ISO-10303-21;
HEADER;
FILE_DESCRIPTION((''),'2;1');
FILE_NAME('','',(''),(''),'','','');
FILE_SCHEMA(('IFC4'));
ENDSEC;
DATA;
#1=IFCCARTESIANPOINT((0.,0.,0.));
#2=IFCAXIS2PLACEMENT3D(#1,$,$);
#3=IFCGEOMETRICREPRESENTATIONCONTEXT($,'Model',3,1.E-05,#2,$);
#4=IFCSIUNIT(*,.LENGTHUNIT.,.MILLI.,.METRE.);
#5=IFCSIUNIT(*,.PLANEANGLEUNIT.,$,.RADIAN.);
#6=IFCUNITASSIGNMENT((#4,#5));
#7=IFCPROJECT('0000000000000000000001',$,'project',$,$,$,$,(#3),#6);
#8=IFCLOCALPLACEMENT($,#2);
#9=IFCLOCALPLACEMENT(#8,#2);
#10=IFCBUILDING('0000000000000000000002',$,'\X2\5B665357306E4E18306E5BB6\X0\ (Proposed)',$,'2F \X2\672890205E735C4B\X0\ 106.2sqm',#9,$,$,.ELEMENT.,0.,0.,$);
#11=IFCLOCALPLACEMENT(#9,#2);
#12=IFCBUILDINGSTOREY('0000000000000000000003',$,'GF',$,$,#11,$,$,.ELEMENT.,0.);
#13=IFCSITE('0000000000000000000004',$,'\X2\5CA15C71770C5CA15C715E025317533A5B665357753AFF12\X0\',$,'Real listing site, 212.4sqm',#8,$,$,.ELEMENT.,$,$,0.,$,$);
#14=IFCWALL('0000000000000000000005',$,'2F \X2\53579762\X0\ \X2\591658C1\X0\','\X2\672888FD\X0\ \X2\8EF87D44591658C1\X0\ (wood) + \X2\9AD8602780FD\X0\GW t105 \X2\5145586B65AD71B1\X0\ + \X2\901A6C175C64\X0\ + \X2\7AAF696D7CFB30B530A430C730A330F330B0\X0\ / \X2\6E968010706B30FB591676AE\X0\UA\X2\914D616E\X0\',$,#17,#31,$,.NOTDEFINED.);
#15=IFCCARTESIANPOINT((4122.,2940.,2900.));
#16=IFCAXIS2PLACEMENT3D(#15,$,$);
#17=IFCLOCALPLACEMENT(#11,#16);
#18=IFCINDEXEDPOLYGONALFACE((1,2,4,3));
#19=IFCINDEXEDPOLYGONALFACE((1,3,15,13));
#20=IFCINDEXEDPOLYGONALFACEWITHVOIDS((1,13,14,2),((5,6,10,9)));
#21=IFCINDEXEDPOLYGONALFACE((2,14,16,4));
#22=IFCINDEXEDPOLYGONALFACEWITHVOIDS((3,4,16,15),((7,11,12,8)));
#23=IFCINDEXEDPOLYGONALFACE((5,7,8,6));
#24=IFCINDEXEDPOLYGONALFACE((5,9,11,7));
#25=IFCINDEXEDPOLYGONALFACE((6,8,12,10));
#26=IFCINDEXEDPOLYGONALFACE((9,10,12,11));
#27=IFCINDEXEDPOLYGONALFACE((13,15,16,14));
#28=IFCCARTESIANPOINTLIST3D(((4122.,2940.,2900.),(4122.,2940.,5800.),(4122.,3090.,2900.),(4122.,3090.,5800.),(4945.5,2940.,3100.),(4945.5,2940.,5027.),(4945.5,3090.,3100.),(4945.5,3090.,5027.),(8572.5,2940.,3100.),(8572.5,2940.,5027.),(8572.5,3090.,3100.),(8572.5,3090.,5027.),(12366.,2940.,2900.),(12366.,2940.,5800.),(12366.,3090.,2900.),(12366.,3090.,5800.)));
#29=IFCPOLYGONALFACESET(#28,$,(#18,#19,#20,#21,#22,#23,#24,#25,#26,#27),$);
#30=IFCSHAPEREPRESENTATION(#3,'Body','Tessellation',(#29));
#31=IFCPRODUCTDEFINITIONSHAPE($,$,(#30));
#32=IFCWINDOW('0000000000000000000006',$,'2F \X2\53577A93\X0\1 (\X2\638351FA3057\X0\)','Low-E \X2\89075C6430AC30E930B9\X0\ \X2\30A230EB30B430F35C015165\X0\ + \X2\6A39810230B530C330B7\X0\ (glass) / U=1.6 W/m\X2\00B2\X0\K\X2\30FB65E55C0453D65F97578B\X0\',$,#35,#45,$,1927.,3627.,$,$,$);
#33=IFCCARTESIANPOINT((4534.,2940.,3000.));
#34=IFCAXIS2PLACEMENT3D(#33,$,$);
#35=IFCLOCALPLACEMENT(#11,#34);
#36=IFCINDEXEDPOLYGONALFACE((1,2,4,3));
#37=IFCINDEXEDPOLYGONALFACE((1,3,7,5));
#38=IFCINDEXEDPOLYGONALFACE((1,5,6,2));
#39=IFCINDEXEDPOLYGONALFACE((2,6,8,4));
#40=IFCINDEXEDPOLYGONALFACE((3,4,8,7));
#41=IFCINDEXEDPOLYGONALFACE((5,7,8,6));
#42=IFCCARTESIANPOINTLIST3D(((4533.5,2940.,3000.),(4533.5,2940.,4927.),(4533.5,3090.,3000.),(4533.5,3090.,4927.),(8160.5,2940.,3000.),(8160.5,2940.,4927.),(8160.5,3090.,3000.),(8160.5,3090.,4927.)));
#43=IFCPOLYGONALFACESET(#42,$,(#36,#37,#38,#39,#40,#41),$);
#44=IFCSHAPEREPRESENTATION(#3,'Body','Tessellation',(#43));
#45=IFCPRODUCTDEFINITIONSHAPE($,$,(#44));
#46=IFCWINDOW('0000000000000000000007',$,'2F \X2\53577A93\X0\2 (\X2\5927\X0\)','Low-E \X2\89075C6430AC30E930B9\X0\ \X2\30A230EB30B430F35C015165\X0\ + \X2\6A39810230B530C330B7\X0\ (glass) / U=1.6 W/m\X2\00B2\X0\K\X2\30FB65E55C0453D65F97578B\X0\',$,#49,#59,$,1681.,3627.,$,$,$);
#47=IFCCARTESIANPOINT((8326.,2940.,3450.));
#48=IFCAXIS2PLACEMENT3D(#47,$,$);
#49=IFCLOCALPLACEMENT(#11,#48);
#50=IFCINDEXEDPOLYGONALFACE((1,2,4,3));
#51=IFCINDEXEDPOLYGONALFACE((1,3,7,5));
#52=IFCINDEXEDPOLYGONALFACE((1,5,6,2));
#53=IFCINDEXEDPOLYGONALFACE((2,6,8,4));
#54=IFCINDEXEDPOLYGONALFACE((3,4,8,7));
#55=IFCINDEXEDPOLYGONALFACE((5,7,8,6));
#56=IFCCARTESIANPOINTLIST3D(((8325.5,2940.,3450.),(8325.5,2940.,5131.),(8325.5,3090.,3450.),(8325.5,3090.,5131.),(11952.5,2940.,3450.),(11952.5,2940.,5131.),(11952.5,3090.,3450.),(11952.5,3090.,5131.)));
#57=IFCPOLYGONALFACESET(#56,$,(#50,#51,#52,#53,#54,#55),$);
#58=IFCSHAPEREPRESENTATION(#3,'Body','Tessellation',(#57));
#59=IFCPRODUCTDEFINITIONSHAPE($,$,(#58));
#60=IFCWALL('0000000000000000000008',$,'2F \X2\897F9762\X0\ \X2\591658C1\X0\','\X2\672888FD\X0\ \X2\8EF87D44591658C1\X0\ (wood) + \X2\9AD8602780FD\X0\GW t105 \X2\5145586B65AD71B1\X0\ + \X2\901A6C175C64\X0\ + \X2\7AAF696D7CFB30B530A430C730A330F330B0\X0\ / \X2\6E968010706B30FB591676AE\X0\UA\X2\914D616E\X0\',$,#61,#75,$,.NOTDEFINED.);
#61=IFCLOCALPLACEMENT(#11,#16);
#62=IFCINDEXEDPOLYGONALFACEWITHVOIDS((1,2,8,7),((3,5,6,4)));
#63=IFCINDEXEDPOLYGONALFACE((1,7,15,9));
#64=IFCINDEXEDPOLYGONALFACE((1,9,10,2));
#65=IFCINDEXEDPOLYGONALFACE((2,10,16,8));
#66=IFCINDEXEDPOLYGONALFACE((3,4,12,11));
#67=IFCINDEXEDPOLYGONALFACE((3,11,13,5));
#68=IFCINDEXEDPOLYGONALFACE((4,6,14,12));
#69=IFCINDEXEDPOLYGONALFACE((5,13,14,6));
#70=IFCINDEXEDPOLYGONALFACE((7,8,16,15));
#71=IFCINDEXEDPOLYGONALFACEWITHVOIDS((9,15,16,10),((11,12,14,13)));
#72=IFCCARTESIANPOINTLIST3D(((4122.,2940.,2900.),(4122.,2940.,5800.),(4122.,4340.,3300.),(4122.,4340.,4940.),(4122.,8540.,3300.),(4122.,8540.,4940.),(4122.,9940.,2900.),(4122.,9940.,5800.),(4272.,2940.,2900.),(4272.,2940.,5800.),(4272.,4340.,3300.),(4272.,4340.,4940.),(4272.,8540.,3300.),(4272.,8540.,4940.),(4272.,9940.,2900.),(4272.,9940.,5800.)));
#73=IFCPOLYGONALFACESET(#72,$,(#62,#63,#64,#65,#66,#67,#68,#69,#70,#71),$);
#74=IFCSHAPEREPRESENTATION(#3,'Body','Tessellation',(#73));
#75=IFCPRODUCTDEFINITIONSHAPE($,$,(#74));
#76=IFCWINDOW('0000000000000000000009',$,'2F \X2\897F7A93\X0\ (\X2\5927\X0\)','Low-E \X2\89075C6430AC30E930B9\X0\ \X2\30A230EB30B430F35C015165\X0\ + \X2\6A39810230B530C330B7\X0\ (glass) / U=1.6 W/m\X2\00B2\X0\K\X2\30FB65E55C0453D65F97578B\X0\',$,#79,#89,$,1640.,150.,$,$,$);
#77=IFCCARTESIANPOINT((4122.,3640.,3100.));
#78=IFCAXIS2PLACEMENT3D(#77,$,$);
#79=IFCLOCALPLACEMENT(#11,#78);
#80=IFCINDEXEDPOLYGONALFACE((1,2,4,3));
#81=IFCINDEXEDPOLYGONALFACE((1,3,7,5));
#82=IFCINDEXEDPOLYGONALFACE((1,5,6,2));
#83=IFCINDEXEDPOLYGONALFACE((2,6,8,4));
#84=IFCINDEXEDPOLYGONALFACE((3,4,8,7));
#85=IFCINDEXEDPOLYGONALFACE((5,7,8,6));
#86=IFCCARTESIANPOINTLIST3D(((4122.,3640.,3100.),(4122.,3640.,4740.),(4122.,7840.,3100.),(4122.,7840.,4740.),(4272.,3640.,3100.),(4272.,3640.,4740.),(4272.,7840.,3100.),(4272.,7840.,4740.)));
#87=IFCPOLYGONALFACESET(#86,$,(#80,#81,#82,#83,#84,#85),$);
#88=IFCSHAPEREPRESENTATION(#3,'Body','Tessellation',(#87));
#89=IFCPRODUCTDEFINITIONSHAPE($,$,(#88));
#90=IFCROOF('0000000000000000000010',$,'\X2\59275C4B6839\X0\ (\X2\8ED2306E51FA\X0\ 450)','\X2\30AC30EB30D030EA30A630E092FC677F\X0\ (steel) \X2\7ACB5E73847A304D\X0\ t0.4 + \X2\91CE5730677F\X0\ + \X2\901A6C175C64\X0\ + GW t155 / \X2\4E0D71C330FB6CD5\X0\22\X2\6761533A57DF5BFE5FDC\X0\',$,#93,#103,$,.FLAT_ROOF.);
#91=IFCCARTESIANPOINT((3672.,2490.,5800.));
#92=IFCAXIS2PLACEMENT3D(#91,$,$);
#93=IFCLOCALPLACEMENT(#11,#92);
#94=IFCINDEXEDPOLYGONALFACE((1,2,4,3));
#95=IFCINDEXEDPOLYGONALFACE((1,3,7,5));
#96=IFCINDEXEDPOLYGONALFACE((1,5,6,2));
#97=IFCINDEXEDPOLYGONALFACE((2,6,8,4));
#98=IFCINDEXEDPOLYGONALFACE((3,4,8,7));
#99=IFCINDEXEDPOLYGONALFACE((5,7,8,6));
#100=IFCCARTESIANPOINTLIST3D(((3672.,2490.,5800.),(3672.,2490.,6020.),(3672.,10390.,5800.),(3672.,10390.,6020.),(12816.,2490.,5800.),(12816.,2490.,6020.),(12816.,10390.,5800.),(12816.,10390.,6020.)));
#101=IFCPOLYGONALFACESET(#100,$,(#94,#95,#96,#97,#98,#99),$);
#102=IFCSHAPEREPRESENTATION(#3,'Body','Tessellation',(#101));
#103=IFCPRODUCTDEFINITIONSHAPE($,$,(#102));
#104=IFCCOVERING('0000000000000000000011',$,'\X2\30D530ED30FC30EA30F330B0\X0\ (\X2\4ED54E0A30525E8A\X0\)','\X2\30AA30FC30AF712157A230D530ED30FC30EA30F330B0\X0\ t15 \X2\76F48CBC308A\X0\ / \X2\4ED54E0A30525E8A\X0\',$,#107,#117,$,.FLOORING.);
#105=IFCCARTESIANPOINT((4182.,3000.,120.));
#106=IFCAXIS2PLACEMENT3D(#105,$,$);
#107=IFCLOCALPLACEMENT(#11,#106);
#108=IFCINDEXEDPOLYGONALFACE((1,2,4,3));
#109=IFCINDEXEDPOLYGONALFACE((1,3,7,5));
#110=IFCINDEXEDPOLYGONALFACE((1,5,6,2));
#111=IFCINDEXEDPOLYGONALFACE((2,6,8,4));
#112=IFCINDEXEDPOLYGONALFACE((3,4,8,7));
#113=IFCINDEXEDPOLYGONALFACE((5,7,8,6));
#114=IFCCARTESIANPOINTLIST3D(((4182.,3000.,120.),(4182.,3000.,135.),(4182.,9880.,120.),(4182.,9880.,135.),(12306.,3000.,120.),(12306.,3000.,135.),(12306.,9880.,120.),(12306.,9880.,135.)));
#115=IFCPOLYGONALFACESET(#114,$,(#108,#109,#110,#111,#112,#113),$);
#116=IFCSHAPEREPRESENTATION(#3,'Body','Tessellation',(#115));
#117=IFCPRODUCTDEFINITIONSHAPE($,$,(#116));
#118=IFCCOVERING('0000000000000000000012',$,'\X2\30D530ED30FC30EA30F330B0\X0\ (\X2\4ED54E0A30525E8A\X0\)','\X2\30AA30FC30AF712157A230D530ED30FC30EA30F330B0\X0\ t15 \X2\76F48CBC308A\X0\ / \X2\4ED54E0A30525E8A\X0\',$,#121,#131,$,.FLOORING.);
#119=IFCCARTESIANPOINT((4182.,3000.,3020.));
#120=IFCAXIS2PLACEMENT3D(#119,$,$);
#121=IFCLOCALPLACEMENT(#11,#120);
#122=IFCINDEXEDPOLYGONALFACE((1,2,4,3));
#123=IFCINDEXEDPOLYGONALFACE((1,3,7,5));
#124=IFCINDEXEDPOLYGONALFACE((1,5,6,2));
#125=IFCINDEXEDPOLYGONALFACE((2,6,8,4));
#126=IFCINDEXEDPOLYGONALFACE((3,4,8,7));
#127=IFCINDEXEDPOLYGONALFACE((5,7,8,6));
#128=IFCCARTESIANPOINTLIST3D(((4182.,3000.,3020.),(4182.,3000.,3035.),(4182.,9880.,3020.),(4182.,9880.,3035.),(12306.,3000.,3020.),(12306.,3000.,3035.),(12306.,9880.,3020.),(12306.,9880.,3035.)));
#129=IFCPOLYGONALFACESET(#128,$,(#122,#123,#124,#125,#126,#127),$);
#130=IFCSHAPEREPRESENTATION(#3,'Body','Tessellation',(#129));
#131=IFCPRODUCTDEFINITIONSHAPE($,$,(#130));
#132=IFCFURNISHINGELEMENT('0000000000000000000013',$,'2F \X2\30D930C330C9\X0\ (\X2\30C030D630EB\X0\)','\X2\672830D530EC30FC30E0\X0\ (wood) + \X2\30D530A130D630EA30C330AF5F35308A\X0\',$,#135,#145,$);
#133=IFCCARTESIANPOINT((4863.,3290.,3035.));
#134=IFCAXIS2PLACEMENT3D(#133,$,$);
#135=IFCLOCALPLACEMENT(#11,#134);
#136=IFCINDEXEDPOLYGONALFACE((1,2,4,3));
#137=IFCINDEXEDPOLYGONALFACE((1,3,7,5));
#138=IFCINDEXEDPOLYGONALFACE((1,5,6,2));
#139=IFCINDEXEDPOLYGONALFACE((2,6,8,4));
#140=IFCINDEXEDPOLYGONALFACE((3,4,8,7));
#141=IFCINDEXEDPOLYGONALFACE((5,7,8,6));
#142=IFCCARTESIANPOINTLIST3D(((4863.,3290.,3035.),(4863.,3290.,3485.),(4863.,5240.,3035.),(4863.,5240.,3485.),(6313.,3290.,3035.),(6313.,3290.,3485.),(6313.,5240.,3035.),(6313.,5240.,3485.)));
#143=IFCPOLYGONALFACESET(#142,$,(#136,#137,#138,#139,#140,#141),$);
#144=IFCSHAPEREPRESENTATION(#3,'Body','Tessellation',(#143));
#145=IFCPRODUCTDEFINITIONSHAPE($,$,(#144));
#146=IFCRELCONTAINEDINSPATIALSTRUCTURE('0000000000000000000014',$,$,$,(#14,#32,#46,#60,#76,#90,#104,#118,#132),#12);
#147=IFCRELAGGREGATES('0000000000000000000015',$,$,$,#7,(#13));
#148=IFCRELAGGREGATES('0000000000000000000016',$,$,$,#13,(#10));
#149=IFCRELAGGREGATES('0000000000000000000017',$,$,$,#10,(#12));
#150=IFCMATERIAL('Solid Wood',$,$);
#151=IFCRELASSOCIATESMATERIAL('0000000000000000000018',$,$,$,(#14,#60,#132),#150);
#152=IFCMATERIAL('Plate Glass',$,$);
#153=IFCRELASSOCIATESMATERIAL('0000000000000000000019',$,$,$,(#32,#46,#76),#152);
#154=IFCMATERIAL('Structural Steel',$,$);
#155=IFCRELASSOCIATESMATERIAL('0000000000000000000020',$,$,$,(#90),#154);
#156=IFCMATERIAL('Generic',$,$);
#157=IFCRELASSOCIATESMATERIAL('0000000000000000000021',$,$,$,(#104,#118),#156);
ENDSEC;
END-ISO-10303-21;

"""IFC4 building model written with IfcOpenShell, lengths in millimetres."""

from ifc_helpers import new_model, si_unit, frame, frame_2d, origin, place, context, project, spatial, rectangle, extrude, material, element, fill, save


model = new_model("IFC4")

# Units and contexts
model_context = context("Model", 3, precision=1e-05, world=origin())
ifc_project = project(units=[si_unit("LENGTHUNIT", "METRE", prefix="MILLI"), si_unit("PLANEANGLEUNIT", "RADIAN")], contexts=[model_context])

# Site, building, storey
site_placement = place(None, origin())
site = spatial("IfcSite", under=ifc_project, at=site_placement, Name="岡山県岡山市北区学南町２", ObjectType="Real listing site, 212.4sqm", CompositionType="ELEMENT", RefElevation=0.0)
building_placement = place(site_placement, origin())
building = spatial("IfcBuilding", under=site, at=building_placement, Name="学南の丘の家 (Proposed)", ObjectType="2F 木造平屋 106.2sqm", CompositionType="ELEMENT", ElevationOfRefHeight=0.0, ElevationOfTerrain=0.0)
storey_placement = place(building_placement, origin())
storey = spatial("IfcBuildingStorey", under=building, at=storey_placement, Name="GF", CompositionType="ELEMENT", Elevation=0.0)

# Shared definitions
ifc_material_1 = material(Name="Solid Wood")

# Shared definitions
ifc_material_2 = material(Name="Plate Glass")

# Wall, openings, windows
wall_1_placement = place(storey_placement, frame((4122.0, 2940.0, 2900.0)))
wall_1 = element("IfcWall", 1, at=wall_1_placement, inside=storey, material=ifc_material_1, Name="2F 南面 外壁", Description="木製 軸組外壁 (wood) + 高性能GW t105 充填断熱 + 通気層 + 窯業系サイディング / 準耐火・外皮UA配慮", PredefinedType="NOTDEFINED", context=model_context, shape_type="SweptSolid", body=[
    extrude(rectangle(XDim=8244.0, YDim=150.0, at=frame_2d((4122.0, 75.0))), frame((4122.0, 2940.0, 2900.0)), (0.0, 0.0, 1.0), 2900.0),
])
opening_1_placement = place(storey_placement, frame((4534.0, 2940.0, 3000.0)))
opening_1 = element("IfcOpeningElement", 2, at=opening_1_placement, cuts=wall_1, PredefinedType="NOTDEFINED", context=model_context, shape_type="SweptSolid", body=[
    extrude(rectangle(XDim=3627.0, YDim=150.0, at=frame_2d((1813.0, 75.0))), frame((4534.0, 2940.0, 3000.0)), (0.0, 0.0, 1.0), 1927.0),
])
opening_2_placement = place(storey_placement, frame((8326.0, 2940.0, 3450.0)))
opening_2 = element("IfcOpeningElement", 3, at=opening_2_placement, cuts=wall_1, PredefinedType="NOTDEFINED", context=model_context, shape_type="SweptSolid", body=[
    extrude(rectangle(XDim=3627.0, YDim=150.0, at=frame_2d((1813.0, 75.0))), frame((8326.0, 2940.0, 3450.0)), (0.0, 0.0, 1.0), 1681.0),
])
window_1_placement = place(storey_placement, frame((4534.0, 2940.0, 3000.0)))
window_1 = element("IfcWindow", 4, at=window_1_placement, inside=storey, material=ifc_material_2, Name="2F 南窓1 (掃出し)", Description="Low-E 複層ガラス アルゴン封入 + 樹脂サッシ (glass) / U=1.6 W/m²K・日射取得型", OverallHeight=1927.0, OverallWidth=3627.0, context=model_context, shape_type="SweptSolid", body=[
    extrude(rectangle(XDim=3627.0, YDim=150.0, at=frame_2d((1813.0, 75.0))), frame((4534.0, 2940.0, 3000.0)), (0.0, 0.0, 1.0), 1927.0),
])
fill(opening_1, window_1)
window_2_placement = place(storey_placement, frame((8326.0, 2940.0, 3450.0)))
window_2 = element("IfcWindow", 5, at=window_2_placement, inside=storey, material=ifc_material_2, Name="2F 南窓2 (大)", Description="Low-E 複層ガラス アルゴン封入 + 樹脂サッシ (glass) / U=1.6 W/m²K・日射取得型", OverallHeight=1681.0, OverallWidth=3627.0, context=model_context, shape_type="SweptSolid", body=[
    extrude(rectangle(XDim=3627.0, YDim=150.0, at=frame_2d((1813.0, 75.0))), frame((8326.0, 2940.0, 3450.0)), (0.0, 0.0, 1.0), 1681.0),
])
fill(opening_2, window_2)

# Wall, opening, window
wall_2_placement = place(storey_placement, frame((4122.0, 2940.0, 2900.0)))
wall_2 = element("IfcWall", 6, at=wall_2_placement, inside=storey, material=ifc_material_1, Name="2F 西面 外壁", Description="木製 軸組外壁 (wood) + 高性能GW t105 充填断熱 + 通気層 + 窯業系サイディング / 準耐火・外皮UA配慮", PredefinedType="NOTDEFINED", context=model_context, shape_type="SweptSolid", body=[
    extrude(rectangle(XDim=150.0, YDim=7000.0, at=frame_2d((75.0, 3500.0))), frame((4122.0, 2940.0, 2900.0)), (0.0, 0.0, 1.0), 2900.0),
])
opening_3_placement = place(storey_placement, frame((4122.0, 3640.0, 3100.0)))
opening_3 = element("IfcOpeningElement", 7, at=opening_3_placement, cuts=wall_2, PredefinedType="NOTDEFINED", context=model_context, shape_type="SweptSolid", body=[
    extrude(rectangle(XDim=150.0, YDim=4200.0, at=frame_2d((75.0, 2100.0))), frame((4122.0, 3640.0, 3100.0)), (0.0, 0.0, 1.0), 1640.0),
])
window_3_placement = place(storey_placement, frame((4122.0, 3640.0, 3100.0)))
window_3 = element("IfcWindow", 8, at=window_3_placement, inside=storey, material=ifc_material_2, Name="2F 西窓 (大)", Description="Low-E 複層ガラス アルゴン封入 + 樹脂サッシ (glass) / U=1.6 W/m²K・日射取得型", OverallHeight=1640.0, OverallWidth=150.0, context=model_context, shape_type="SweptSolid", body=[
    extrude(rectangle(XDim=150.0, YDim=4200.0, at=frame_2d((75.0, 2100.0))), frame((4122.0, 3640.0, 3100.0)), (0.0, 0.0, 1.0), 1640.0),
])
fill(opening_3, window_3)

# Roof
ifc_material_3 = material(Name="Structural Steel")
roof_placement = place(storey_placement, frame((3672.0, 2490.0, 5800.0)))
element("IfcRoof", 9, at=roof_placement, inside=storey, material=ifc_material_3, Name="大屋根 (軒の出 450)", Description="ガルバリウム鋼板 (steel) 立平葺き t0.4 + 野地板 + 通気層 + GW t155 / 不燃・法22条区域対応", PredefinedType="FLAT_ROOF", context=model_context, shape_type="SweptSolid", body=[
    extrude(rectangle(XDim=9144.0, YDim=7900.0, at=frame_2d((4572.0, 3950.0))), frame((3672.0, 2490.0, 5800.0)), (0.0, 0.0, 1.0), 220.0),
])

# Coverings
ifc_material_4 = material(Name="Generic")
covering_1_placement = place(storey_placement, frame((4182.0, 3000.0, 120.0)))
element("IfcCovering", 10, at=covering_1_placement, inside=storey, material=ifc_material_4, Name="フローリング (仕上げ床)", Description="オーク無垢フローリング t15 直貼り / 仕上げ床", PredefinedType="FLOORING", context=model_context, shape_type="SweptSolid", body=[
    extrude(rectangle(XDim=8124.0, YDim=6880.0, at=frame_2d((4062.0, 3440.0))), frame((4182.0, 3000.0, 120.0)), (0.0, 0.0, 1.0), 15.0),
])
covering_2_placement = place(storey_placement, frame((4182.0, 3000.0, 3020.0)))
element("IfcCovering", 11, at=covering_2_placement, inside=storey, material=ifc_material_4, Name="フローリング (仕上げ床)", Description="オーク無垢フローリング t15 直貼り / 仕上げ床", PredefinedType="FLOORING", context=model_context, shape_type="SweptSolid", body=[
    extrude(rectangle(XDim=8124.0, YDim=6880.0, at=frame_2d((4062.0, 3440.0))), frame((4182.0, 3000.0, 3020.0)), (0.0, 0.0, 1.0), 15.0),
])

# Furnishing element
furnishing_placement = place(storey_placement, frame((4863.0, 3290.0, 3035.0)))
element("IfcFurnishingElement", 12, at=furnishing_placement, inside=storey, material=ifc_material_1, Name="2F ベッド (ダブル)", Description="木フレーム (wood) + ファブリック張り", context=model_context, shape_type="SweptSolid", body=[
    extrude(rectangle(XDim=1450.0, YDim=1950.0, at=frame_2d((725.0, 975.0))), frame((4863.0, 3290.0, 3035.0)), (0.0, 0.0, 1.0), 450.0),
])

save(model, "model.ifc")
